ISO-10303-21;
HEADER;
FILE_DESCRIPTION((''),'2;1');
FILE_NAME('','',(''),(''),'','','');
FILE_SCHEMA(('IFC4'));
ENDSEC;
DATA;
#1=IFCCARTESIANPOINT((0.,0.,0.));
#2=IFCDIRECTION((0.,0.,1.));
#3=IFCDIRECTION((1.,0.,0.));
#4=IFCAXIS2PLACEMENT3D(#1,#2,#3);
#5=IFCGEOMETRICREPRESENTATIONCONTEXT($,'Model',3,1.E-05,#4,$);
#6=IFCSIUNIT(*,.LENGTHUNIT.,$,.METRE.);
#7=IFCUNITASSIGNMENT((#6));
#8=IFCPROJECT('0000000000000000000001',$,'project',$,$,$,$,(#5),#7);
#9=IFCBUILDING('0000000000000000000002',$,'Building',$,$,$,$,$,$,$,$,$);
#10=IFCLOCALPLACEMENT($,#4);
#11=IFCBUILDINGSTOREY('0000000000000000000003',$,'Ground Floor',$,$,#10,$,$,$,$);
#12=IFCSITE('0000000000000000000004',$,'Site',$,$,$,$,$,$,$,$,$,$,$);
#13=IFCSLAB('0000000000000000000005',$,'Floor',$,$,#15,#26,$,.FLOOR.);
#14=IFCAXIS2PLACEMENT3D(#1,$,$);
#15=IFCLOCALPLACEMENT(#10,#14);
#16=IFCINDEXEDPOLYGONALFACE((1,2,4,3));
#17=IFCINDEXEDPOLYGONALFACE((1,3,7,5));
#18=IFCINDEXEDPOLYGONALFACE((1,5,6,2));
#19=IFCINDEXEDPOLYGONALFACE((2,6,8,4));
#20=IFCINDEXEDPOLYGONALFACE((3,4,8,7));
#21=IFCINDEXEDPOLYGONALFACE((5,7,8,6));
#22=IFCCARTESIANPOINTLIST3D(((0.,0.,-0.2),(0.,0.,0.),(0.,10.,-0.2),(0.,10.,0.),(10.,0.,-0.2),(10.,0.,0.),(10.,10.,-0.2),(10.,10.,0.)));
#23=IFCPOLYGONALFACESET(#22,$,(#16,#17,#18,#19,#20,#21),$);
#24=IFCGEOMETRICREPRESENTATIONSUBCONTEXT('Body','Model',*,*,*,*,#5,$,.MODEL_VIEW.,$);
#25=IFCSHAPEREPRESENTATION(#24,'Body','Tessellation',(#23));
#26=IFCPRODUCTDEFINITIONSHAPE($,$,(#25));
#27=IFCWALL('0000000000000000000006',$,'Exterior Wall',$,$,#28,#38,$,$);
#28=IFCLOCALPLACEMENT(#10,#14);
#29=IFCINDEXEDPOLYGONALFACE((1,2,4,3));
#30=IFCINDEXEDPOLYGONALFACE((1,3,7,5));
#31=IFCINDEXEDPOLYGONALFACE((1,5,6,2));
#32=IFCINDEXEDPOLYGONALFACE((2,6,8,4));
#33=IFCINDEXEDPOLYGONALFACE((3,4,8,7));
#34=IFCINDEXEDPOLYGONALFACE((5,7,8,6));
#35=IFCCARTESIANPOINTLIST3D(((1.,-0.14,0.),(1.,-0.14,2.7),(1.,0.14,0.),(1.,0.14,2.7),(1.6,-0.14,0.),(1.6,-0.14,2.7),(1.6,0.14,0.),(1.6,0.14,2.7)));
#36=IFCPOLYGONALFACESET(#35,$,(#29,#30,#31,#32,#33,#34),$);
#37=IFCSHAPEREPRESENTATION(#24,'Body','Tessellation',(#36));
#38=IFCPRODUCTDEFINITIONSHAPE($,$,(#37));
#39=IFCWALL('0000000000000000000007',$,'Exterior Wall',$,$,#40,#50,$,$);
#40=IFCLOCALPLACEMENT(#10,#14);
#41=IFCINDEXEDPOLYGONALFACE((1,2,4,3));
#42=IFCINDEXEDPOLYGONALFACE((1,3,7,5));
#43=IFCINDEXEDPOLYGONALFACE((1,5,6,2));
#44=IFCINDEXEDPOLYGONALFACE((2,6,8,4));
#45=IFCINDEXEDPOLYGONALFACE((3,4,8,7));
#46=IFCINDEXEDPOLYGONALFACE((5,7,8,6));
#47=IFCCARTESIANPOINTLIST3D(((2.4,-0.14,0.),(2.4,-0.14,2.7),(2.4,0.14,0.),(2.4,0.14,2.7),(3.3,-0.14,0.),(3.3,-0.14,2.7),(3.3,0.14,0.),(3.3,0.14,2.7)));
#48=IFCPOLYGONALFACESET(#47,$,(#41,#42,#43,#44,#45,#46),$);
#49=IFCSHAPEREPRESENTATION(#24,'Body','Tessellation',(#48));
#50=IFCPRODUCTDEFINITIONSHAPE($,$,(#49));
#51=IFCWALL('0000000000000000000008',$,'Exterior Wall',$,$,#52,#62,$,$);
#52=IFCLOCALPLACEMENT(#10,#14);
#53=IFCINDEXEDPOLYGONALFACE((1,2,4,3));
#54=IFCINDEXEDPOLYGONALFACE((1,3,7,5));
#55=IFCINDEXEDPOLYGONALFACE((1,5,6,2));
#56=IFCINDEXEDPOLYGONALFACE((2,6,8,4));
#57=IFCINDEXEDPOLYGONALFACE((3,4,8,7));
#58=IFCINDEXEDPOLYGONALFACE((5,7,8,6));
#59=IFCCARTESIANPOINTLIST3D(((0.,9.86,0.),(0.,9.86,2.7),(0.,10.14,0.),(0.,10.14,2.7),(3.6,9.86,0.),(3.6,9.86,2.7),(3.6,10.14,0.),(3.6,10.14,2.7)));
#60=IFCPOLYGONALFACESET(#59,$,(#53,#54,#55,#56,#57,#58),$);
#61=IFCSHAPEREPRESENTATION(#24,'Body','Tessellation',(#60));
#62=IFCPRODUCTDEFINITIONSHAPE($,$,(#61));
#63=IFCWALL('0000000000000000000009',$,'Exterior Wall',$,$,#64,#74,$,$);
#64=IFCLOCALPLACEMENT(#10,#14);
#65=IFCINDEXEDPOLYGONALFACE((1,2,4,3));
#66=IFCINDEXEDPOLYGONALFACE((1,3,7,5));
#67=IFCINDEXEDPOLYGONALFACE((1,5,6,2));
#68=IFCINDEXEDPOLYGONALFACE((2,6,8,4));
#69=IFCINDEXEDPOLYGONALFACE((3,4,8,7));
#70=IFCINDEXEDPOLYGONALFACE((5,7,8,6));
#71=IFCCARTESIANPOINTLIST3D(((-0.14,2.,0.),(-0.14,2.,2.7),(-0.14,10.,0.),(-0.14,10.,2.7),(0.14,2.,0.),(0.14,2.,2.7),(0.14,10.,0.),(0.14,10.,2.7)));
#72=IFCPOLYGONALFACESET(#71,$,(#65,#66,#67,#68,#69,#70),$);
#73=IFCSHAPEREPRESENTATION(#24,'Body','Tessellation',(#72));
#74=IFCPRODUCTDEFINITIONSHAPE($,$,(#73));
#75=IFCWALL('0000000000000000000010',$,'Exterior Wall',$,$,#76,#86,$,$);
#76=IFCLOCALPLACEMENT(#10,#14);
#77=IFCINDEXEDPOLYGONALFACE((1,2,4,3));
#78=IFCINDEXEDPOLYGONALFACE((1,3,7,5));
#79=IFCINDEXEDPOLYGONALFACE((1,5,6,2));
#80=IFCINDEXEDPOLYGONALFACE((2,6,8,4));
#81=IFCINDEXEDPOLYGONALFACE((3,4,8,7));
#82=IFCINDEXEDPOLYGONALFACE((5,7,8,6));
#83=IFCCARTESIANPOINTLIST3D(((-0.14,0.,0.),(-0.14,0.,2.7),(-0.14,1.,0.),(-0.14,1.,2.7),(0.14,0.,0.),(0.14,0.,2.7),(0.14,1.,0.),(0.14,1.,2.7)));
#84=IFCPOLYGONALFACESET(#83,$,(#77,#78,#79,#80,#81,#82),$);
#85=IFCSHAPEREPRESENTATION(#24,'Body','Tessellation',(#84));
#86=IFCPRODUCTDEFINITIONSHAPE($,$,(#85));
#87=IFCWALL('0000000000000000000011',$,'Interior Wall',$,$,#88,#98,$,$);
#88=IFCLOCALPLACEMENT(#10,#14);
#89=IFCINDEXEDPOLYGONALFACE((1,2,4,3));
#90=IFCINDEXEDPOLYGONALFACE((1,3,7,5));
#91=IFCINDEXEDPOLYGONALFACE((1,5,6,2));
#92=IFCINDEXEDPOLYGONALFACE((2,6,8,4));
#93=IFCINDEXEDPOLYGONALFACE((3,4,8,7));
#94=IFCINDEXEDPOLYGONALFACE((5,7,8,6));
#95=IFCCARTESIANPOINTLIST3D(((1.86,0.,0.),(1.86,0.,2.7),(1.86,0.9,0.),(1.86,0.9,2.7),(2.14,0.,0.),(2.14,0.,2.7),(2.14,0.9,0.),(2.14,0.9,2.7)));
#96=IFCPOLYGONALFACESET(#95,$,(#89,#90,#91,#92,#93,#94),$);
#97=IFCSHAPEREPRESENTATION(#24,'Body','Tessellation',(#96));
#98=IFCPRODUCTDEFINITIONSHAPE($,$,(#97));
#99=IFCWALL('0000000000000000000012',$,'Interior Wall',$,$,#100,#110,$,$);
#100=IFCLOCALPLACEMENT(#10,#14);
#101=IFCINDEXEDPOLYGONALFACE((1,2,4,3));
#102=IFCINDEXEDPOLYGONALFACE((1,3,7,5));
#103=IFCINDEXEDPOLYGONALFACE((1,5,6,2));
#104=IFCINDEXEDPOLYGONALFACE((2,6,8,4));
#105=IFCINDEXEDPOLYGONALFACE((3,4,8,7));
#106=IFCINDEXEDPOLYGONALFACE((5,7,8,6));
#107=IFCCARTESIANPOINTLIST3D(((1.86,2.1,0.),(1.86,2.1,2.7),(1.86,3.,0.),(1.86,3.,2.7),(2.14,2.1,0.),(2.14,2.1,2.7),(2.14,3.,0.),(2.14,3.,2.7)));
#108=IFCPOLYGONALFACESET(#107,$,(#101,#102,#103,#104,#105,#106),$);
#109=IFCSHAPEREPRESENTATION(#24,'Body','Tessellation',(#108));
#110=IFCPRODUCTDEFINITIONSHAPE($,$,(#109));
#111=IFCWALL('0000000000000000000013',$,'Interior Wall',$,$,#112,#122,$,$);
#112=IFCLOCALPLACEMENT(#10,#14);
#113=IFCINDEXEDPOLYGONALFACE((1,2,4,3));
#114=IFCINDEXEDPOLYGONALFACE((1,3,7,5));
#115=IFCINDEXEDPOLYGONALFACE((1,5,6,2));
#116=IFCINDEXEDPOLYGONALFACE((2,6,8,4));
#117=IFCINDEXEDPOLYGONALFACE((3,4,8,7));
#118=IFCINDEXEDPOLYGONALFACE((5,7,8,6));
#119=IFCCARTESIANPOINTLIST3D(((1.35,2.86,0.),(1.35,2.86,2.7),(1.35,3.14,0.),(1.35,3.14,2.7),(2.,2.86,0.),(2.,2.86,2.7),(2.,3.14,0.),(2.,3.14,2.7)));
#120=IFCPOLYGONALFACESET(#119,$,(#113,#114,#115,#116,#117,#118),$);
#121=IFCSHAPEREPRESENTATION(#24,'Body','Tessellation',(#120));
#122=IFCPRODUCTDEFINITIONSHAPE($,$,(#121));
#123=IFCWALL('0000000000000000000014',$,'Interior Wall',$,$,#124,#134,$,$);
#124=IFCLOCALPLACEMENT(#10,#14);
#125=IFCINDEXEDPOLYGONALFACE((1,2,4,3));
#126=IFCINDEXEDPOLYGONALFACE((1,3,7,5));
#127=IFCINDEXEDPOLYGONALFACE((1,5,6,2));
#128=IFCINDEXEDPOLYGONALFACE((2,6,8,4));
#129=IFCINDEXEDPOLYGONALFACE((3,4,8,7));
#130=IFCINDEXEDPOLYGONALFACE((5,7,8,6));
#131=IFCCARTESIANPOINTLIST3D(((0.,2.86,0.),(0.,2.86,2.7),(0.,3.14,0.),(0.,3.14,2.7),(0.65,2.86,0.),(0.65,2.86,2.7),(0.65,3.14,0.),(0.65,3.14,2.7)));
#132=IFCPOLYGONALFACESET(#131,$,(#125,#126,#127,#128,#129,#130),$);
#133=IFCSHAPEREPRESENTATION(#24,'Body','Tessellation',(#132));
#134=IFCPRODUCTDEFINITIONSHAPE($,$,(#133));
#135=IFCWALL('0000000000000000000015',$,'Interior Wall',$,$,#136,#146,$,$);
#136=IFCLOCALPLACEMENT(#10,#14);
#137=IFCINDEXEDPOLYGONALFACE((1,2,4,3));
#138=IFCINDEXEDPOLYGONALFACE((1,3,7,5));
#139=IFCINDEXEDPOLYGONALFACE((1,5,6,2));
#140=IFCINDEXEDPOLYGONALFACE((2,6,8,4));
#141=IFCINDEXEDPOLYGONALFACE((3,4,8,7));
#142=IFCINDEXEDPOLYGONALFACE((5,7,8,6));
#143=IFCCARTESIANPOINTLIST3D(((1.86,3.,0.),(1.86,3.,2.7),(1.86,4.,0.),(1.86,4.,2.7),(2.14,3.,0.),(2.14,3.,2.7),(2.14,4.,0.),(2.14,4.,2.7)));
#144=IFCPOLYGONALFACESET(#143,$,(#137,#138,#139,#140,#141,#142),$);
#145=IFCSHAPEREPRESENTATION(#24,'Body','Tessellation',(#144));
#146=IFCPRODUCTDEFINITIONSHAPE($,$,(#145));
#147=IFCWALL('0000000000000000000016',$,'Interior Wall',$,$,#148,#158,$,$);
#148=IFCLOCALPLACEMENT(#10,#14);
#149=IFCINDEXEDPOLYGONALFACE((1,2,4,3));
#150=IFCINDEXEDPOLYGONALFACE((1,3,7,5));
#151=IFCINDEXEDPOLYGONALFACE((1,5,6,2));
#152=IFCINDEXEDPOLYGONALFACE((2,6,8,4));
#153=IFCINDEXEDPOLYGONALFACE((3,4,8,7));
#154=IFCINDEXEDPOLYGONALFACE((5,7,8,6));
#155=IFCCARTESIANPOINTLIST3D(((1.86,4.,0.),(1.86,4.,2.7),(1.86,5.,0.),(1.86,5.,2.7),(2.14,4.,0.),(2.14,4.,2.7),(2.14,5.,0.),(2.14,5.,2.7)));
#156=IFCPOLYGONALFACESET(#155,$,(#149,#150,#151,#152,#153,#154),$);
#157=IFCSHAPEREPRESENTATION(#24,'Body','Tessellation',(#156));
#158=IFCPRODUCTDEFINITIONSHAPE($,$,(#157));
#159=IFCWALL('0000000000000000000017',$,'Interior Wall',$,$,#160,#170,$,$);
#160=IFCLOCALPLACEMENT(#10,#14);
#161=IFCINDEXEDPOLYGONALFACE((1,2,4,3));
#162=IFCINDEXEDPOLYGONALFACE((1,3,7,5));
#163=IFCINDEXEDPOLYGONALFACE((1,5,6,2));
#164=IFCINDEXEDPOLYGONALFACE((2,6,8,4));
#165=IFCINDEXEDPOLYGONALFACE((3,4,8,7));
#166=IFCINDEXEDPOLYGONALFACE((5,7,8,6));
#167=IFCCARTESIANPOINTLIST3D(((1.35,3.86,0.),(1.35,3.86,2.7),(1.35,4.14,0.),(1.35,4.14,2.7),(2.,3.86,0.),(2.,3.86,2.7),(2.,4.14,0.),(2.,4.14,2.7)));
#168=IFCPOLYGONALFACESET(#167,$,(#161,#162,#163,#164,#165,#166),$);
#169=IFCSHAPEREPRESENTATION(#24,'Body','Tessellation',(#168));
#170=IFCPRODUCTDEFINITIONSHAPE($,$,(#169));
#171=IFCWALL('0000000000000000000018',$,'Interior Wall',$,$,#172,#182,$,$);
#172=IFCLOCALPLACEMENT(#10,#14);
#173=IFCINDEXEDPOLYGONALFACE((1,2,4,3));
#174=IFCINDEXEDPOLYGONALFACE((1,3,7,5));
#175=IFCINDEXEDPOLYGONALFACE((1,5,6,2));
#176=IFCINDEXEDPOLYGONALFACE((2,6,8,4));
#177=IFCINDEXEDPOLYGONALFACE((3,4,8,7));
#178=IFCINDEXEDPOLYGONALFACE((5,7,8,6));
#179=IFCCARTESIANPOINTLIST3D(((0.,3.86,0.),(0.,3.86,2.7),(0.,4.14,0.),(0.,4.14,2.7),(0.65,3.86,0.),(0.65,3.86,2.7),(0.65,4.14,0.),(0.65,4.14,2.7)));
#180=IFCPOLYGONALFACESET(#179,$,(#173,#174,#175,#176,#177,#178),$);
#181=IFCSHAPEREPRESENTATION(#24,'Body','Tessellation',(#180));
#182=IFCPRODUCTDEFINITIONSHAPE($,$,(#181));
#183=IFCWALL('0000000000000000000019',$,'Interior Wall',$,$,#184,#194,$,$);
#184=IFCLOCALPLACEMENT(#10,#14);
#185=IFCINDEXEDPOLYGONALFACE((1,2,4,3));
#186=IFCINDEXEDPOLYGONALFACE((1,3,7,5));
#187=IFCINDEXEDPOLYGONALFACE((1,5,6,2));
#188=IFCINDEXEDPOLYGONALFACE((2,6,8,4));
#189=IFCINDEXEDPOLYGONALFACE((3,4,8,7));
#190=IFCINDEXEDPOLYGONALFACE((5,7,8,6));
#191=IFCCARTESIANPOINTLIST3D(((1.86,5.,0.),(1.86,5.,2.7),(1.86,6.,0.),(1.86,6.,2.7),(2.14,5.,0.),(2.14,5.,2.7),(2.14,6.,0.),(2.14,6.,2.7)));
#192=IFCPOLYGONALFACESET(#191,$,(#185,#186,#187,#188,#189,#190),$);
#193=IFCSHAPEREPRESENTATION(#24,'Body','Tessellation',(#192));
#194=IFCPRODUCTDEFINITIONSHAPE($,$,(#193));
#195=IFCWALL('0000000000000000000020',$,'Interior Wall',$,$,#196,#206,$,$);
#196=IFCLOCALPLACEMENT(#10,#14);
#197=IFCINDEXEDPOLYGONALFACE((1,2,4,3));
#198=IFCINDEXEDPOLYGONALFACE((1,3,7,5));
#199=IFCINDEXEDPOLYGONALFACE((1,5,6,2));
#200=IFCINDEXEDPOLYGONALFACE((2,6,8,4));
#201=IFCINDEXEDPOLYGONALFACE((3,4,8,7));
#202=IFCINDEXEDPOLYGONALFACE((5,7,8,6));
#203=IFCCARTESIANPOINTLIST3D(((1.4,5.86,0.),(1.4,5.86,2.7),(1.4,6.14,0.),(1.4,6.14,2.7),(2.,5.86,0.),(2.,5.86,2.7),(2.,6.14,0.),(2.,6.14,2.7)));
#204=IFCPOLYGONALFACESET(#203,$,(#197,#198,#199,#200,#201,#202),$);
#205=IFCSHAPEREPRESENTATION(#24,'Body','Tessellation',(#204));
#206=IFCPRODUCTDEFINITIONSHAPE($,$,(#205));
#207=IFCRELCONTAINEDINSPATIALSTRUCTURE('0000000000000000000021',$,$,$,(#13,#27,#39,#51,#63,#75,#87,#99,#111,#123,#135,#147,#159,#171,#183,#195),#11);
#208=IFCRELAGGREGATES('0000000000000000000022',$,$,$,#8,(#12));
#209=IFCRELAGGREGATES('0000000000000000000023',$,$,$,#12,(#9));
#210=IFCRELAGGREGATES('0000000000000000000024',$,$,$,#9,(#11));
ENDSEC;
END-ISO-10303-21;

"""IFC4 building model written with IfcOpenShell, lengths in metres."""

from ifc_helpers import new_model, si_unit, frame, origin_with_axes, place, context, subcontext, project, spatial, indexed_curve, outline, extrude, element, save


model = new_model("IFC4")

# Units and contexts
model_context = context("Model", 3, precision=1e-05, world=origin_with_axes())
body_context = subcontext(model_context, "Body", "Model", "MODEL_VIEW")
ifc_project = project(units=[si_unit("LENGTHUNIT", "METRE")], contexts=[model_context])

# Site, building, storey
site = spatial("IfcSite", under=ifc_project, Name="Site")
building = spatial("IfcBuilding", under=site, Name="Building")
storey_placement = place(None, origin_with_axes())
storey = spatial("IfcBuildingStorey", under=building, at=storey_placement, Name="Ground Floor")

# Slab
slab_placement = place(storey_placement, frame((0.0, 0.0, -0.2), z_axis=(0.0, 0.0, 1.0), x_axis=(1.0, 0.0, 0.0)))
element("IfcSlab", 1, at=slab_placement, inside=storey, Name="Floor", PredefinedType="FLOOR", context=body_context, shape_type="SweptSolid", body=[
    extrude(outline(indexed_curve([(0.0, 0.0), (10.0, 0.0), (10.0, 10.0), (0.0, 10.0)])), None, (0.0, 0.0, 1.0), 0.2),
])

# Walls
wall_1_placement = place(storey_placement, frame((1.0, 0.0, 0.0), z_axis=(0.0, 0.0, 1.0), x_axis=(1.0, 0.0, 0.0)))
element("IfcWall", 2, at=wall_1_placement, inside=storey, Name="Exterior Wall", context=body_context, shape_type="SweptSolid", body=[
    extrude(outline(indexed_curve([(0.0, 0.0), (0.0, 0.28), (0.6, 0.28), (0.6, 0.0), (0.0, 0.0)], self_intersect=False)), frame((0.0, -0.14, 0.0), z_axis=(0.0, 0.0, 1.0), x_axis=(1.0, 0.0, 0.0)), (0.0, 0.0, 1.0), 2.7),
])
wall_2_placement = place(storey_placement, frame((2.4, 0.0, 0.0), z_axis=(0.0, 0.0, 1.0), x_axis=(1.0, 0.0, 0.0)))
element("IfcWall", 3, at=wall_2_placement, inside=storey, Name="Exterior Wall", context=body_context, shape_type="SweptSolid", body=[
    extrude(outline(indexed_curve([(0.0, 0.0), (0.0, 0.28), (0.9, 0.28), (0.9, 0.0), (0.0, 0.0)], self_intersect=False)), frame((0.0, -0.14, 0.0), z_axis=(0.0, 0.0, 1.0), x_axis=(1.0, 0.0, 0.0)), (0.0, 0.0, 1.0), 2.7),
])
wall_3_placement = place(storey_placement, frame((3.6, 10.0, 0.0), z_axis=(0.0, 0.0, 1.0), x_axis=(-1.0, 0.0, 0.0)))
element("IfcWall", 4, at=wall_3_placement, inside=storey, Name="Exterior Wall", context=body_context, shape_type="SweptSolid", body=[
    extrude(outline(indexed_curve([(0.0, 0.0), (0.0, 0.28), (3.6, 0.28), (3.6, 0.0), (0.0, 0.0)], self_intersect=False)), frame((0.0, -0.14, 0.0), z_axis=(0.0, 0.0, 1.0), x_axis=(1.0, 0.0, 0.0)), (0.0, 0.0, 1.0), 2.7),
])
wall_4_placement = place(storey_placement, frame((0.0, 10.0, 0.0), z_axis=(0.0, 0.0, 1.0), x_axis=(0.0, -1.0, 0.0)))
element("IfcWall", 5, at=wall_4_placement, inside=storey, Name="Exterior Wall", context=body_context, shape_type="SweptSolid", body=[
    extrude(outline(indexed_curve([(0.0, 0.0), (0.0, 0.28), (8.0, 0.28), (8.0, 0.0), (0.0, 0.0)], self_intersect=False)), frame((0.0, -0.14, 0.0), z_axis=(0.0, 0.0, 1.0), x_axis=(1.0, 0.0, 0.0)), (0.0, 0.0, 1.0), 2.7),
])
wall_5_placement = place(storey_placement, frame((0.0, 1.0, 0.0), z_axis=(0.0, 0.0, 1.0), x_axis=(0.0, -1.0, 0.0)))
element("IfcWall", 6, at=wall_5_placement, inside=storey, Name="Exterior Wall", context=body_context, shape_type="SweptSolid", body=[
    extrude(outline(indexed_curve([(0.0, 0.0), (0.0, 0.28), (1.0, 0.28), (1.0, 0.0), (0.0, 0.0)], self_intersect=False)), frame((0.0, -0.14, 0.0), z_axis=(0.0, 0.0, 1.0), x_axis=(1.0, 0.0, 0.0)), (0.0, 0.0, 1.0), 2.7),
])
wall_6_placement = place(storey_placement, frame((2.0, 0.0, 0.0), z_axis=(0.0, 0.0, 1.0), x_axis=(0.0, 1.0, 0.0)))
element("IfcWall", 7, at=wall_6_placement, inside=storey, Name="Interior Wall", context=body_context, shape_type="SweptSolid", body=[
    extrude(outline(indexed_curve([(0.0, 0.0), (0.0, 0.28), (0.9, 0.28), (0.9, 0.0), (0.0, 0.0)], self_intersect=False)), frame((0.0, -0.14, 0.0), z_axis=(0.0, 0.0, 1.0), x_axis=(1.0, 0.0, 0.0)), (0.0, 0.0, 1.0), 2.7),
])
wall_7_placement = place(storey_placement, frame((2.0, 2.1, 0.0), z_axis=(0.0, 0.0, 1.0), x_axis=(0.0, 1.0, 0.0)))
element("IfcWall", 8, at=wall_7_placement, inside=storey, Name="Interior Wall", context=body_context, shape_type="SweptSolid", body=[
    extrude(outline(indexed_curve([(0.0, 0.0), (0.0, 0.28), (0.9, 0.28), (0.9, 0.0), (0.0, 0.0)], self_intersect=False)), frame((0.0, -0.14, 0.0), z_axis=(0.0, 0.0, 1.0), x_axis=(1.0, 0.0, 0.0)), (0.0, 0.0, 1.0), 2.7),
])
for number, where, z_axis, x_axis, name in (
    (9, (2.0, 3.0, 0.0), (0.0, 0.0, 1.0), (-1.0, 0.0, 0.0), "Interior Wall"),
    (10, (0.65, 3.0, 0.0), (0.0, 0.0, 1.0), (-1.0, 0.0, 0.0), "Interior Wall"),
):
    element("IfcWall", number, at=place(storey_placement, frame(where, z_axis=z_axis, x_axis=x_axis)), inside=storey, Name=name, context=body_context, shape_type="SweptSolid", body=[
        extrude(outline(indexed_curve([(0.0, 0.0), (0.0, 0.28), (0.65, 0.28), (0.65, 0.0), (0.0, 0.0)], self_intersect=False)), frame((0.0, -0.14, 0.0), z_axis=(0.0, 0.0, 1.0), x_axis=(1.0, 0.0, 0.0)), (0.0, 0.0, 1.0), 2.7),
    ])
for number, where, z_axis, x_axis, name in (
    (11, (2.0, 4.0, 0.0), (0.0, 0.0, 1.0), (0.0, -1.0, 0.0), "Interior Wall"),
    (12, (2.0, 5.0, 0.0), (0.0, 0.0, 1.0), (0.0, -1.0, 0.0), "Interior Wall"),
):
    element("IfcWall", number, at=place(storey_placement, frame(where, z_axis=z_axis, x_axis=x_axis)), inside=storey, Name=name, context=body_context, shape_type="SweptSolid", body=[
        extrude(outline(indexed_curve([(0.0, 0.0), (0.0, 0.28), (1.0, 0.28), (1.0, 0.0), (0.0, 0.0)], self_intersect=False)), frame((0.0, -0.14, 0.0), z_axis=(0.0, 0.0, 1.0), x_axis=(1.0, 0.0, 0.0)), (0.0, 0.0, 1.0), 2.7),
    ])
for number, where, z_axis, x_axis, name in (
    (13, (2.0, 4.0, 0.0), (0.0, 0.0, 1.0), (-1.0, 0.0, 0.0), "Interior Wall"),
    (14, (0.65, 4.0, 0.0), (0.0, 0.0, 1.0), (-1.0, 0.0, 0.0), "Interior Wall"),
):
    element("IfcWall", number, at=place(storey_placement, frame(where, z_axis=z_axis, x_axis=x_axis)), inside=storey, Name=name, context=body_context, shape_type="SweptSolid", body=[
        extrude(outline(indexed_curve([(0.0, 0.0), (0.0, 0.28), (0.65, 0.28), (0.65, 0.0), (0.0, 0.0)], self_intersect=False)), frame((0.0, -0.14, 0.0), z_axis=(0.0, 0.0, 1.0), x_axis=(1.0, 0.0, 0.0)), (0.0, 0.0, 1.0), 2.7),
    ])
wall_8_placement = place(storey_placement, frame((2.0, 5.0, 0.0), z_axis=(0.0, 0.0, 1.0), x_axis=(0.0, 1.0, 0.0)))
element("IfcWall", 15, at=wall_8_placement, inside=storey, Name="Interior Wall", context=body_context, shape_type="SweptSolid", body=[
    extrude(outline(indexed_curve([(0.0, 0.0), (0.0, 0.28), (1.0, 0.28), (1.0, 0.0), (0.0, 0.0)], self_intersect=False)), frame((0.0, -0.14, 0.0), z_axis=(0.0, 0.0, 1.0), x_axis=(1.0, 0.0, 0.0)), (0.0, 0.0, 1.0), 2.7),
])
for number, where, z_axis, x_axis, name in (
    (16, (2.0, 6.0, 0.0), (0.0, 0.0, 1.0), (-1.0, 0.0, 0.0), "Interior Wall"),
):
    element("IfcWall", number, at=place(storey_placement, frame(where, z_axis=z_axis, x_axis=x_axis)), inside=storey, Name=name, context=body_context, shape_type="SweptSolid", body=[
        extrude(outline(indexed_curve([(0.0, 0.0), (0.0, 0.28), (0.6, 0.28), (0.6, 0.0), (0.0, 0.0)], self_intersect=False)), frame((0.0, -0.14, 0.0), z_axis=(0.0, 0.0, 1.0), x_axis=(1.0, 0.0, 0.0)), (0.0, 0.0, 1.0), 2.7),
    ])

save(model, "model.ifc")
